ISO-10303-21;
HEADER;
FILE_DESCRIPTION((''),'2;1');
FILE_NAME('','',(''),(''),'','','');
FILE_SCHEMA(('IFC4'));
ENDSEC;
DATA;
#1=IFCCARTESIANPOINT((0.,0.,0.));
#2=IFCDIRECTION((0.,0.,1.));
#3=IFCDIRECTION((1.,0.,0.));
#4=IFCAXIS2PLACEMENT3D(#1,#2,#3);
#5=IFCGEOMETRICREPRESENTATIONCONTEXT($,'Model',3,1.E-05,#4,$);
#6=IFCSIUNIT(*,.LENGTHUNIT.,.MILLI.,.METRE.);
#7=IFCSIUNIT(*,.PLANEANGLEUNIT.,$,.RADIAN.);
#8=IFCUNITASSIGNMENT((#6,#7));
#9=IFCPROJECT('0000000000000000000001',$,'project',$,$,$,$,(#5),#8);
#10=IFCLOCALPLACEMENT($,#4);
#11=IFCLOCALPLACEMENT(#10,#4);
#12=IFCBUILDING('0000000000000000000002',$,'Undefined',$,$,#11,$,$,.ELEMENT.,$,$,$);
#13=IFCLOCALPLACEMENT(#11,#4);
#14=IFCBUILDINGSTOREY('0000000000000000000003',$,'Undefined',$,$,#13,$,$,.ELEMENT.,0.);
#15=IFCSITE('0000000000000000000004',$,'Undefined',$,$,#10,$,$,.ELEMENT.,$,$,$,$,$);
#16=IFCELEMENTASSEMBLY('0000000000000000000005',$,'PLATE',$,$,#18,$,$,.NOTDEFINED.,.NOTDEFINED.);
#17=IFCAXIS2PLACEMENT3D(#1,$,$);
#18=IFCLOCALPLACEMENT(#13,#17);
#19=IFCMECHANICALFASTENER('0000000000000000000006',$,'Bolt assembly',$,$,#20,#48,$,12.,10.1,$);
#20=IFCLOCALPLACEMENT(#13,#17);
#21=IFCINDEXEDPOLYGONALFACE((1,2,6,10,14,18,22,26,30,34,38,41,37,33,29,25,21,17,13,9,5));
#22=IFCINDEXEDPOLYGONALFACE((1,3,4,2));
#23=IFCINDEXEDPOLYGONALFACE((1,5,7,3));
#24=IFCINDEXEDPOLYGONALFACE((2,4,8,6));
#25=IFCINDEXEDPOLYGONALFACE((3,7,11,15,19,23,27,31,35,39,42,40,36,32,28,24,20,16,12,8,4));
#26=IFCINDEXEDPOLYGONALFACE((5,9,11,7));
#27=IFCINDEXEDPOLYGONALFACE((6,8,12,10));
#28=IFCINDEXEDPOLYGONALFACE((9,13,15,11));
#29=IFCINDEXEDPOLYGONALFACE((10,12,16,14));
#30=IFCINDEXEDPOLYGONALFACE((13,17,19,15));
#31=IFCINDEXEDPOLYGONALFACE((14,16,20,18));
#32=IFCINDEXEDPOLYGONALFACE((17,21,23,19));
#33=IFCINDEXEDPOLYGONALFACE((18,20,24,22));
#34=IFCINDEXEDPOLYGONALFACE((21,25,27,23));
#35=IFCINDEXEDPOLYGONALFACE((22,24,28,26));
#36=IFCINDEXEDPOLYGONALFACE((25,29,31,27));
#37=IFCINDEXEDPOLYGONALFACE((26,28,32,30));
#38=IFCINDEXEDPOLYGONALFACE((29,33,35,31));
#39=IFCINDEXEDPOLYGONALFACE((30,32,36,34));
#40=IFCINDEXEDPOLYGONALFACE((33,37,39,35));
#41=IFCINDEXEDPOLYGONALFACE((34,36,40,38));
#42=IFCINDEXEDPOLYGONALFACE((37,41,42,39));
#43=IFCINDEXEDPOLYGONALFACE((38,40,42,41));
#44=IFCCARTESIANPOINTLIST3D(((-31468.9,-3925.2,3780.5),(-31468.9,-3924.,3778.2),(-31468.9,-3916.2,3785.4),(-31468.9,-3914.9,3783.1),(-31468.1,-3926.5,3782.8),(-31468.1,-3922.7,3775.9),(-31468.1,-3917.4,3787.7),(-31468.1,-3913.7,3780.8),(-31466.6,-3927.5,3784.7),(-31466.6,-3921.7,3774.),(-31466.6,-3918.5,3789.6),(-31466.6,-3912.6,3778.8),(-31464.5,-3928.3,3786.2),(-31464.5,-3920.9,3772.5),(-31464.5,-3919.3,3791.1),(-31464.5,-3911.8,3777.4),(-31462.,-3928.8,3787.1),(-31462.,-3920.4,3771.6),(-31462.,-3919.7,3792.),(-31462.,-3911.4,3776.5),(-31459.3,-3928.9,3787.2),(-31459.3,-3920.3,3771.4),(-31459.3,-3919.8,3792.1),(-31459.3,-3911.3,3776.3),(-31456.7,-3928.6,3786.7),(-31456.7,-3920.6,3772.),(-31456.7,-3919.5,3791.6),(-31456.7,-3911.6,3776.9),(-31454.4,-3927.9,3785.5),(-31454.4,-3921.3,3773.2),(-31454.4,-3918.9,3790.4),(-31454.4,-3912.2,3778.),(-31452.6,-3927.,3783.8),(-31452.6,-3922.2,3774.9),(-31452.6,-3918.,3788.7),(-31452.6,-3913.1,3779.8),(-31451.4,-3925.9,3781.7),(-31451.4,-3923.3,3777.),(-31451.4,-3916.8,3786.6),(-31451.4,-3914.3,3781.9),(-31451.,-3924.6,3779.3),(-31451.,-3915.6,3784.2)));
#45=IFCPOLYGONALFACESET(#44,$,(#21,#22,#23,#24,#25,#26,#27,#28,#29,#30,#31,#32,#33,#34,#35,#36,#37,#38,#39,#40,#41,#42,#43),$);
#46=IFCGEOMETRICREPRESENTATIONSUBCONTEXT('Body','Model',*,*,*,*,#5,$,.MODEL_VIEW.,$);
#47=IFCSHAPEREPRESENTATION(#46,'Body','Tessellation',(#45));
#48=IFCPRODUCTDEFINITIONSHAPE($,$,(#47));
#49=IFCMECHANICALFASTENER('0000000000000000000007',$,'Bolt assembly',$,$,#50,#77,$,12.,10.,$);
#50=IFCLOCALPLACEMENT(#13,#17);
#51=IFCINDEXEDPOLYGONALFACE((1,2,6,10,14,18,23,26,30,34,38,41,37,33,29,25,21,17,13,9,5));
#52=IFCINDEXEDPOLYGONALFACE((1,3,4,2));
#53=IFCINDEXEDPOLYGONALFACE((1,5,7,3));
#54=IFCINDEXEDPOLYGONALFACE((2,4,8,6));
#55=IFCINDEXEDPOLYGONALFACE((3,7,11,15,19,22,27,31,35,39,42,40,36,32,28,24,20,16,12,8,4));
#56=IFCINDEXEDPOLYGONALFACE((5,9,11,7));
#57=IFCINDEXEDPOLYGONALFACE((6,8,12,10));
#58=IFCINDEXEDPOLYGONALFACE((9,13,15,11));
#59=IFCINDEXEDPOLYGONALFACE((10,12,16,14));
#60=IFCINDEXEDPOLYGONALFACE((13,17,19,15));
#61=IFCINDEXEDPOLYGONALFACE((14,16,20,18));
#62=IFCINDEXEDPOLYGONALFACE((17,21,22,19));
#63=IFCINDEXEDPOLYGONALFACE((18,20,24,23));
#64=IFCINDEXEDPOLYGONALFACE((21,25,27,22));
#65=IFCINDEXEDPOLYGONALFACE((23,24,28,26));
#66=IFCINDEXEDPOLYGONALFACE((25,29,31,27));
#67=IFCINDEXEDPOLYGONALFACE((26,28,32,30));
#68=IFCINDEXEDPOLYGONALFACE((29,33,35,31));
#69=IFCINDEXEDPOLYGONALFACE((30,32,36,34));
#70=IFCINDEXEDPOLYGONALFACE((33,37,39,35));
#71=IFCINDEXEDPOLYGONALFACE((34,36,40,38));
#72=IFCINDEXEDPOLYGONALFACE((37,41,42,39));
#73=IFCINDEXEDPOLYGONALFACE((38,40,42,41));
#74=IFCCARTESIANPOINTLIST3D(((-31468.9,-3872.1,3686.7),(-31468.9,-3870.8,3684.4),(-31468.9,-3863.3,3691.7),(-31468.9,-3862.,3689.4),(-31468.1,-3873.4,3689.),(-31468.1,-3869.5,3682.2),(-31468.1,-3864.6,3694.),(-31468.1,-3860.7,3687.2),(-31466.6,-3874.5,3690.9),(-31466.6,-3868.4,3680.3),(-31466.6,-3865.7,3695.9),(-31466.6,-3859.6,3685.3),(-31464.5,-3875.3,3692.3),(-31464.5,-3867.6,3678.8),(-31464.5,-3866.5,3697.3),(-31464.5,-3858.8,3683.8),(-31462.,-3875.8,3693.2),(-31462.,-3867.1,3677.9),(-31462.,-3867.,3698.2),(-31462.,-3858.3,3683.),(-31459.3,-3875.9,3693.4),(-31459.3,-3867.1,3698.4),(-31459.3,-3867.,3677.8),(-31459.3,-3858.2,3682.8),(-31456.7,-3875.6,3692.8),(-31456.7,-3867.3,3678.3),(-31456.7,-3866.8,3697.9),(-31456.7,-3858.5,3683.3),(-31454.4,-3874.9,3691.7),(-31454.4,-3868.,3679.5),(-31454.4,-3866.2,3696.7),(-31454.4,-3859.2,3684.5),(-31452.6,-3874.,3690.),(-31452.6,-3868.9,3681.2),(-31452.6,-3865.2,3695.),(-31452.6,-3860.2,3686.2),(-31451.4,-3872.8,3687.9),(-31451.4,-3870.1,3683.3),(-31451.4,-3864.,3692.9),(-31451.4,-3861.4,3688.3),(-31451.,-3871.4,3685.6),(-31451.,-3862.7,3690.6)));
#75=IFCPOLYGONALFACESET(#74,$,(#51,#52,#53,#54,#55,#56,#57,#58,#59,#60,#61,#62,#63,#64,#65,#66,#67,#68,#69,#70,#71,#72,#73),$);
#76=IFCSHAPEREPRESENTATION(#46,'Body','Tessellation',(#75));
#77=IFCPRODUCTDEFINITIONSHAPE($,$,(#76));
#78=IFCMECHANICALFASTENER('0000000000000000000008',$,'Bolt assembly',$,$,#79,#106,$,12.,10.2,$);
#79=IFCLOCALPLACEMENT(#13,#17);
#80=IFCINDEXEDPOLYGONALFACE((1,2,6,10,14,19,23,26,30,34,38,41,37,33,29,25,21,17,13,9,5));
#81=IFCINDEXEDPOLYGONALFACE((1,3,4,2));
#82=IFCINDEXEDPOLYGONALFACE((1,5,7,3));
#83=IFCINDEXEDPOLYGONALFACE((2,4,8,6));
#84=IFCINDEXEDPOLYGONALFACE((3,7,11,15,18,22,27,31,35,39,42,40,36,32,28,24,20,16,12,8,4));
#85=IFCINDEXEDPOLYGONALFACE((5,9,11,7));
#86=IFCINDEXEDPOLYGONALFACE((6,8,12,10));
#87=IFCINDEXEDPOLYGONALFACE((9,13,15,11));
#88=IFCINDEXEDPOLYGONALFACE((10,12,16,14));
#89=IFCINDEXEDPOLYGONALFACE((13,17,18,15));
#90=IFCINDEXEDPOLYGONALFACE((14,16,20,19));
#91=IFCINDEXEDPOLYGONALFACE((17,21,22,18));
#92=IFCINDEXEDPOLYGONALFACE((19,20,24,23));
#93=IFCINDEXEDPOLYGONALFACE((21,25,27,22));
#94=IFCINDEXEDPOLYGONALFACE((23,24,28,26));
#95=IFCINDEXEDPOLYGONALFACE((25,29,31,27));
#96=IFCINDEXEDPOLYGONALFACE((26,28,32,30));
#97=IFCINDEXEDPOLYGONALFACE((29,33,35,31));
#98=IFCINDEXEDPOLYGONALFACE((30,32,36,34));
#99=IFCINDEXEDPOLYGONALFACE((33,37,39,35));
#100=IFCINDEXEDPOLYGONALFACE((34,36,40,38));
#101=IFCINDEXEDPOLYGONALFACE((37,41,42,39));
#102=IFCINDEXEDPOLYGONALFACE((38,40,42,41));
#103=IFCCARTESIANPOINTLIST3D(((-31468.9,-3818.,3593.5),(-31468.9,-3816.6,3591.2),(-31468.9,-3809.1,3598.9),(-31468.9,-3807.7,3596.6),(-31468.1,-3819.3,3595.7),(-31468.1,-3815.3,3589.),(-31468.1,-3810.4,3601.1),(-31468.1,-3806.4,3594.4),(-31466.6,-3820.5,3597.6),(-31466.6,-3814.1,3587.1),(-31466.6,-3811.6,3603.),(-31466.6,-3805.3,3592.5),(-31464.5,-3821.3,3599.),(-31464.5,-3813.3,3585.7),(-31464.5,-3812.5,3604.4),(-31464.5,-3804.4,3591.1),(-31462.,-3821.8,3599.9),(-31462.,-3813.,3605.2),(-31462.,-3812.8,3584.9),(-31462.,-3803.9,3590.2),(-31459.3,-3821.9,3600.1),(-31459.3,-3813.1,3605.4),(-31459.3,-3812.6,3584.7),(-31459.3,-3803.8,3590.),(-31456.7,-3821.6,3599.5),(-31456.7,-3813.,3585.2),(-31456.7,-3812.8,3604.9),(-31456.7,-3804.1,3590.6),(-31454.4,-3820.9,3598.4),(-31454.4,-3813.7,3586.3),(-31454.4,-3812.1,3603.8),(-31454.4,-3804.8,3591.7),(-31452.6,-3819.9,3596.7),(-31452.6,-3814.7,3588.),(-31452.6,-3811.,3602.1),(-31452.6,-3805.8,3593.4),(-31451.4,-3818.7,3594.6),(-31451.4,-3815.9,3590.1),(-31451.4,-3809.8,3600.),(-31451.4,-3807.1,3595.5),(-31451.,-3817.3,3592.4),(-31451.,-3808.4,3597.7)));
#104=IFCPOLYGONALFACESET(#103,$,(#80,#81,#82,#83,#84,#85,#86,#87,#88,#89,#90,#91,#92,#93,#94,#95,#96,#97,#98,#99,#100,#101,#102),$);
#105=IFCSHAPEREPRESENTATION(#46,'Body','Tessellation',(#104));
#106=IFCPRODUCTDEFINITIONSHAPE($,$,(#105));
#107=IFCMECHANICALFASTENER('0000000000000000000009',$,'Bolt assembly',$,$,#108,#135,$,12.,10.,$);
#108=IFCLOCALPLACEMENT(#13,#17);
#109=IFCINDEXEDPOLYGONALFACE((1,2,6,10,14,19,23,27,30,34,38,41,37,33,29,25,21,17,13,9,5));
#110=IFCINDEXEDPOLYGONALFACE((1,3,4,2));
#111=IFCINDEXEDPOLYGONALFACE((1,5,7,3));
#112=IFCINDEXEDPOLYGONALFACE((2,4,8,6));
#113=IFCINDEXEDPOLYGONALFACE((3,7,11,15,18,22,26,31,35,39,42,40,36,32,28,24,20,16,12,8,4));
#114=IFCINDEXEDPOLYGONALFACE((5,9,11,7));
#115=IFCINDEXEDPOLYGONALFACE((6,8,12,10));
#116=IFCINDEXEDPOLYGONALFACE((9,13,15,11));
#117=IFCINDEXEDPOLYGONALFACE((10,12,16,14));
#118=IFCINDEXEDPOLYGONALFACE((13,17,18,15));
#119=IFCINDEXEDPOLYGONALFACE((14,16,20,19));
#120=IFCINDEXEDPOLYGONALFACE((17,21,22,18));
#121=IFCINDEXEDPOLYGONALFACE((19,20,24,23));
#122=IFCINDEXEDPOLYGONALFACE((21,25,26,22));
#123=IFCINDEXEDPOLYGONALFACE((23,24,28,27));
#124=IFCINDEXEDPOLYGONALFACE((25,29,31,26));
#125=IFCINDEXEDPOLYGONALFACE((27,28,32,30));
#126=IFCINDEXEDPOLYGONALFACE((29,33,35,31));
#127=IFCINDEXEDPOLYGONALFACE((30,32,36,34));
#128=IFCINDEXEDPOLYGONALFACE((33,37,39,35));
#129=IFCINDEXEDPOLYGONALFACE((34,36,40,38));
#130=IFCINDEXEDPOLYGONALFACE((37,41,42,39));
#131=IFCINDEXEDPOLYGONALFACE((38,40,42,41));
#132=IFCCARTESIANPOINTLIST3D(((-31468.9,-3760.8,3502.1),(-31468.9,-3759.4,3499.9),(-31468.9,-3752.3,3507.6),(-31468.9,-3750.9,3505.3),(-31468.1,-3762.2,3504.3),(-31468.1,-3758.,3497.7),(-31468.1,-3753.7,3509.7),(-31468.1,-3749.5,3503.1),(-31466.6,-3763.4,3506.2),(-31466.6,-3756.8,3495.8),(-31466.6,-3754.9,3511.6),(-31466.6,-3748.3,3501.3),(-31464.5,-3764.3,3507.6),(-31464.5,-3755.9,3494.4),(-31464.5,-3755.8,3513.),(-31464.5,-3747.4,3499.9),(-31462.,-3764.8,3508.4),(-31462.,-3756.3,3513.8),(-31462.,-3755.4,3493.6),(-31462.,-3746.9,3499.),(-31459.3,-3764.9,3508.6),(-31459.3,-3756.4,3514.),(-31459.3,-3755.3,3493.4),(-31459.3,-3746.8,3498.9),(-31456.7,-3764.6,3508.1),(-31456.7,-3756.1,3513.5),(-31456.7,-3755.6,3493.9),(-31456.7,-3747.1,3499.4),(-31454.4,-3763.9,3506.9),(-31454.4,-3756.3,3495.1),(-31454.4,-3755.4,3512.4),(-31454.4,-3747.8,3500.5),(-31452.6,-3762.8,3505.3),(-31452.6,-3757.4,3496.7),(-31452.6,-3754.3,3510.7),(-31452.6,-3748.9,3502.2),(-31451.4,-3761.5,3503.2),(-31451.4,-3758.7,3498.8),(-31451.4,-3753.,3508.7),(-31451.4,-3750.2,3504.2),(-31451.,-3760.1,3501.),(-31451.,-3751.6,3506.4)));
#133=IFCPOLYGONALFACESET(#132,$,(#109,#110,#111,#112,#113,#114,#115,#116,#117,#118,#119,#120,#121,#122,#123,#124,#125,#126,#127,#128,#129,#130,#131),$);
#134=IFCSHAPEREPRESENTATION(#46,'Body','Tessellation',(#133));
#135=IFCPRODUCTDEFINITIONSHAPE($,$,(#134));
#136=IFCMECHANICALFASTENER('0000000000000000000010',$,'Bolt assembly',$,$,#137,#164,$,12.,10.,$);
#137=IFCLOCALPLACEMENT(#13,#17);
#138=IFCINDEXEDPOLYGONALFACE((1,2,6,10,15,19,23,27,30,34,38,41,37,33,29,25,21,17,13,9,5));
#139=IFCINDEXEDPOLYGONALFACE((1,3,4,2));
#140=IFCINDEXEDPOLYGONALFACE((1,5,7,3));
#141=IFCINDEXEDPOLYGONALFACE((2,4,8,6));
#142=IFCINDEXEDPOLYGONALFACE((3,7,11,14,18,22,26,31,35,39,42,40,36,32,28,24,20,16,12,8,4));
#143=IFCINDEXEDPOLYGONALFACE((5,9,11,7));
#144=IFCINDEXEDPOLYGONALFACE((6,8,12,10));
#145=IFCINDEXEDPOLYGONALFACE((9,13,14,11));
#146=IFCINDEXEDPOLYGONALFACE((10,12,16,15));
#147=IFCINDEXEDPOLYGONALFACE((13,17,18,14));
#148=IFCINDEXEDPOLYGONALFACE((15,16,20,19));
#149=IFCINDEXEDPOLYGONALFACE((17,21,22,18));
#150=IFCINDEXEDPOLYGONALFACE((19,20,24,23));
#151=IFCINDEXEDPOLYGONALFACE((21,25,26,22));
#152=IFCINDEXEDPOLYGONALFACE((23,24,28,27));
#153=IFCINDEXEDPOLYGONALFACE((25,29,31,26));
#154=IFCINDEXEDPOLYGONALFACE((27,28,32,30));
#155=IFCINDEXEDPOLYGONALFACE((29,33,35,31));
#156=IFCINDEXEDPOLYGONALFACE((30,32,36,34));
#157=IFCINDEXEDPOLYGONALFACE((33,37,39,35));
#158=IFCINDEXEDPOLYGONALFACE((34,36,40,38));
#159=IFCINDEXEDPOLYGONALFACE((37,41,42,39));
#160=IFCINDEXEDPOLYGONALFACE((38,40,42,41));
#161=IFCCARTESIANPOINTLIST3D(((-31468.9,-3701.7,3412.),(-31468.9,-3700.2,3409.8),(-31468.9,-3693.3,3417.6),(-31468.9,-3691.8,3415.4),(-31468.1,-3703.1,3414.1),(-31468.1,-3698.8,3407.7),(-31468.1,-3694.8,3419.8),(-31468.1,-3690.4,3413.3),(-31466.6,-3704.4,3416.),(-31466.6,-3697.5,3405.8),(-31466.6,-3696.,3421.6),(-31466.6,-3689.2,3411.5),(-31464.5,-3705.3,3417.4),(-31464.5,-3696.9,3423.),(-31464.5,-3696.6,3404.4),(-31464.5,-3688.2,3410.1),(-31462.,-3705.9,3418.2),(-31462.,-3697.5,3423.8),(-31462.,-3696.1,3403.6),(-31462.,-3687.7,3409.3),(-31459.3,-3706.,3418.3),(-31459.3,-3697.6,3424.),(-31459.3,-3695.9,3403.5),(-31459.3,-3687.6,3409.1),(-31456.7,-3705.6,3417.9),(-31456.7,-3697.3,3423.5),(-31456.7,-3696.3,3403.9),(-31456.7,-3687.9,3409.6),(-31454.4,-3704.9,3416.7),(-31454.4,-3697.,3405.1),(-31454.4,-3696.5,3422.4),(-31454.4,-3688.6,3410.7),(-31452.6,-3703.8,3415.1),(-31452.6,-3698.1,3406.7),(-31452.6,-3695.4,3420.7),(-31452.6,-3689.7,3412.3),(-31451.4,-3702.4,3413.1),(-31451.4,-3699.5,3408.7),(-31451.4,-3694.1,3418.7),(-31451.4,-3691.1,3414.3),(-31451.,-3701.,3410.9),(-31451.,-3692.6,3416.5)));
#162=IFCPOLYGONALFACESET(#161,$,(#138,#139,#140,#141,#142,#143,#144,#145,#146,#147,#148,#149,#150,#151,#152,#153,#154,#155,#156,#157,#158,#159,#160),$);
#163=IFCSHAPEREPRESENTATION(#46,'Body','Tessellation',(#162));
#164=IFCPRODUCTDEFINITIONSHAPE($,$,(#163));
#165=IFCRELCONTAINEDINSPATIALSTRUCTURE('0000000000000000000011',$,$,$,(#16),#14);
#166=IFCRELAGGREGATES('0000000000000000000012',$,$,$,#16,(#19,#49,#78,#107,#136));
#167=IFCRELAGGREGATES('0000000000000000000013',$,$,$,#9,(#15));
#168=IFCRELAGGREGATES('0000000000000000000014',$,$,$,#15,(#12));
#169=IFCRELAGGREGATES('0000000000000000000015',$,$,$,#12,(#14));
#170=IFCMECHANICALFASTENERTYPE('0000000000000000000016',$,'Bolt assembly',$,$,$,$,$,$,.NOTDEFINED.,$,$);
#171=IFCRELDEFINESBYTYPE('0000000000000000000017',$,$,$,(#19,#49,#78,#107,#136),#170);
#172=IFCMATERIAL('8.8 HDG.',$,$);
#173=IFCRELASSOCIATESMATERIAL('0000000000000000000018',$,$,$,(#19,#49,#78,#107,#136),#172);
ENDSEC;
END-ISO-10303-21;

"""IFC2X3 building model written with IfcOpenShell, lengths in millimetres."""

from ifc_helpers import new_model, si_unit, frame, origin_with_axes, origin_2d_with_axis, place, context, subcontext, project, spatial, circle, extrude, source, transform, mapped, material, type_object, element, aggregate, save


model = new_model("IFC2X3")

# Units and contexts
model_context = context("Model", 3, precision=1e-05, world=origin_with_axes())
body_context = subcontext(model_context, "Body", "Model", "MODEL_VIEW")
ifc_project = project(units=[si_unit("LENGTHUNIT", "METRE", prefix="MILLI"), si_unit("PLANEANGLEUNIT", "RADIAN")], contexts=[model_context])

# Site, building, storey
site_placement = place(None, origin_with_axes())
site = spatial("IfcSite", under=ifc_project, at=site_placement, Name="Undefined", CompositionType="ELEMENT")
building_placement = place(site_placement, origin_with_axes())
building = spatial("IfcBuilding", under=site, at=building_placement, Name="Undefined", CompositionType="ELEMENT")
storey_placement = place(building_placement, origin_with_axes())
storey = spatial("IfcBuildingStorey", under=building, at=storey_placement, Name="Undefined", CompositionType="ELEMENT", Elevation=0.0)

# Element assembly
assembly_1_placement = place(storey_placement, origin_with_axes())
assembly_1 = element("IfcElementAssembly", 1, at=assembly_1_placement, inside=storey, Name="PLATE", AssemblyPlace="NOTDEFINED", PredefinedType="NOTDEFINED")

# Shared definitions
mechanical_fastener_type = type_object("IfcMechanicalFastenerType", Name="Bolt assembly")

# Mechanical fasteners
ifc_material_1 = material(Name="8.8 HDG.")
shared_shape_1 = source(origin_with_axes(), body_context, "Body", "SweptSolid", [
    extrude(circle(Radius=9.0, at=origin_2d_with_axis()), frame((0.0, 0.1, 0.0), z_axis=(0.0, 1.0, 0.0), x_axis=(1.0, 0.0, 0.0)), (0.0, 0.0, 1.0), 10.3),
])
mechanical_fastener_1_placement = place(assembly_1_placement, frame((-31460.0, -3924.6, 3779.3), z_axis=(0.000001, -0.475388, 0.879776), x_axis=(1.0, 0.0, -0.000001)))
mechanical_fastener_1 = element("IfcMechanicalFastener", 2, at=mechanical_fastener_1_placement, type_object=mechanical_fastener_type, material=ifc_material_1, Name="Bolt assembly", NominalDiameter=12.0, NominalLength=10.1, context=body_context, shape_type="MappedRepresentation", body=[
    mapped(shared_shape_1, transform((0.0, 0.0, 0.0))),
])
shared_shape_2 = source(origin_with_axes(), body_context, "Body", "SweptSolid", [
    extrude(circle(Radius=9.0, at=origin_2d_with_axis()), frame((0.0, 0.9, 0.0), z_axis=(0.0, 1.0, 0.0), x_axis=(1.0, 0.0, 0.0)), (0.0, 0.0, 1.0), 10.1),
])
mechanical_fastener_2_placement = place(assembly_1_placement, frame((-31460.0, -3872.3, 3685.1), z_axis=(0.000001, -0.496508, 0.868032), x_axis=(1.0, 0.0, -0.000001)))
mechanical_fastener_2 = element("IfcMechanicalFastener", 3, at=mechanical_fastener_2_placement, type_object=mechanical_fastener_type, material=ifc_material_1, Name="Bolt assembly", NominalDiameter=12.0, NominalLength=10.0, context=body_context, shape_type="MappedRepresentation", body=[
    mapped(shared_shape_2, transform((0.0, 0.0, 0.0))),
])
shared_shape_3 = source(origin_with_axes(), body_context, "Body", "SweptSolid", [
    extrude(circle(Radius=9.0, at=origin_2d_with_axis()), frame((0.0, 0.4, 0.0), z_axis=(0.0, 1.0, 0.0), x_axis=(1.0, 0.0, 0.0)), (0.0, 0.0, 1.0), 10.4),
])
mechanical_fastener_3_placement = place(assembly_1_placement, frame((-31460.0, -3817.6, 3592.2), z_axis=(0.000001, -0.517338, 0.855781), x_axis=(1.0, 0.0, -0.000001)))
mechanical_fastener_3 = element("IfcMechanicalFastener", 4, at=mechanical_fastener_3_placement, type_object=mechanical_fastener_type, material=ifc_material_1, Name="Bolt assembly", NominalDiameter=12.0, NominalLength=10.2, context=body_context, shape_type="MappedRepresentation", body=[
    mapped(shared_shape_3, transform((0.0, 0.0, 0.0))),
])
shared_shape_4 = source(origin_with_axes(), body_context, "Body", "SweptSolid", [
    extrude(circle(Radius=9.0, at=origin_2d_with_axis()), frame((0.0, 0.7, 0.0), z_axis=(0.0, 1.0, 0.0), x_axis=(1.0, 0.0, 0.0)), (0.0, 0.0, 1.0), 10.1),
])
mechanical_fastener_4_placement = place(assembly_1_placement, frame((-31460.0, -3760.7, 3500.6), z_axis=(0.000001, -0.537866, 0.843031), x_axis=(1.0, 0.0, -0.000001)))
mechanical_fastener_4 = element("IfcMechanicalFastener", 5, at=mechanical_fastener_4_placement, type_object=mechanical_fastener_type, material=ifc_material_1, Name="Bolt assembly", NominalDiameter=12.0, NominalLength=10.0, context=body_context, shape_type="MappedRepresentation", body=[
    mapped(shared_shape_4, transform((0.0, 0.0, 0.0))),
])
shared_shape_5 = source(origin_with_axes(), body_context, "Body", "SweptSolid", [
    extrude(circle(Radius=9.0, at=origin_2d_with_axis()), frame((0.0, 0.8, 0.0), z_axis=(0.0, 1.0, 0.0), x_axis=(1.0, 0.0, 0.0)), (0.0, 0.0, 1.0), 10.1),
])
mechanical_fastener_5_placement = place(assembly_1_placement, frame((-31460.0, -3701.6, 3410.4), z_axis=(0.000001, -0.558079, 0.829788), x_axis=(1.0, 0.000001, -0.000001)))
mechanical_fastener_5 = element("IfcMechanicalFastener", 6, at=mechanical_fastener_5_placement, type_object=mechanical_fastener_type, material=ifc_material_1, Name="Bolt assembly", NominalDiameter=12.0, NominalLength=10.0, context=body_context, shape_type="MappedRepresentation", body=[
    mapped(shared_shape_5, transform((0.0, 0.0, 0.0))),
])
aggregate(assembly_1, [mechanical_fastener_1, mechanical_fastener_2, mechanical_fastener_3, mechanical_fastener_4, mechanical_fastener_5])

save(model, "model.ifc")
